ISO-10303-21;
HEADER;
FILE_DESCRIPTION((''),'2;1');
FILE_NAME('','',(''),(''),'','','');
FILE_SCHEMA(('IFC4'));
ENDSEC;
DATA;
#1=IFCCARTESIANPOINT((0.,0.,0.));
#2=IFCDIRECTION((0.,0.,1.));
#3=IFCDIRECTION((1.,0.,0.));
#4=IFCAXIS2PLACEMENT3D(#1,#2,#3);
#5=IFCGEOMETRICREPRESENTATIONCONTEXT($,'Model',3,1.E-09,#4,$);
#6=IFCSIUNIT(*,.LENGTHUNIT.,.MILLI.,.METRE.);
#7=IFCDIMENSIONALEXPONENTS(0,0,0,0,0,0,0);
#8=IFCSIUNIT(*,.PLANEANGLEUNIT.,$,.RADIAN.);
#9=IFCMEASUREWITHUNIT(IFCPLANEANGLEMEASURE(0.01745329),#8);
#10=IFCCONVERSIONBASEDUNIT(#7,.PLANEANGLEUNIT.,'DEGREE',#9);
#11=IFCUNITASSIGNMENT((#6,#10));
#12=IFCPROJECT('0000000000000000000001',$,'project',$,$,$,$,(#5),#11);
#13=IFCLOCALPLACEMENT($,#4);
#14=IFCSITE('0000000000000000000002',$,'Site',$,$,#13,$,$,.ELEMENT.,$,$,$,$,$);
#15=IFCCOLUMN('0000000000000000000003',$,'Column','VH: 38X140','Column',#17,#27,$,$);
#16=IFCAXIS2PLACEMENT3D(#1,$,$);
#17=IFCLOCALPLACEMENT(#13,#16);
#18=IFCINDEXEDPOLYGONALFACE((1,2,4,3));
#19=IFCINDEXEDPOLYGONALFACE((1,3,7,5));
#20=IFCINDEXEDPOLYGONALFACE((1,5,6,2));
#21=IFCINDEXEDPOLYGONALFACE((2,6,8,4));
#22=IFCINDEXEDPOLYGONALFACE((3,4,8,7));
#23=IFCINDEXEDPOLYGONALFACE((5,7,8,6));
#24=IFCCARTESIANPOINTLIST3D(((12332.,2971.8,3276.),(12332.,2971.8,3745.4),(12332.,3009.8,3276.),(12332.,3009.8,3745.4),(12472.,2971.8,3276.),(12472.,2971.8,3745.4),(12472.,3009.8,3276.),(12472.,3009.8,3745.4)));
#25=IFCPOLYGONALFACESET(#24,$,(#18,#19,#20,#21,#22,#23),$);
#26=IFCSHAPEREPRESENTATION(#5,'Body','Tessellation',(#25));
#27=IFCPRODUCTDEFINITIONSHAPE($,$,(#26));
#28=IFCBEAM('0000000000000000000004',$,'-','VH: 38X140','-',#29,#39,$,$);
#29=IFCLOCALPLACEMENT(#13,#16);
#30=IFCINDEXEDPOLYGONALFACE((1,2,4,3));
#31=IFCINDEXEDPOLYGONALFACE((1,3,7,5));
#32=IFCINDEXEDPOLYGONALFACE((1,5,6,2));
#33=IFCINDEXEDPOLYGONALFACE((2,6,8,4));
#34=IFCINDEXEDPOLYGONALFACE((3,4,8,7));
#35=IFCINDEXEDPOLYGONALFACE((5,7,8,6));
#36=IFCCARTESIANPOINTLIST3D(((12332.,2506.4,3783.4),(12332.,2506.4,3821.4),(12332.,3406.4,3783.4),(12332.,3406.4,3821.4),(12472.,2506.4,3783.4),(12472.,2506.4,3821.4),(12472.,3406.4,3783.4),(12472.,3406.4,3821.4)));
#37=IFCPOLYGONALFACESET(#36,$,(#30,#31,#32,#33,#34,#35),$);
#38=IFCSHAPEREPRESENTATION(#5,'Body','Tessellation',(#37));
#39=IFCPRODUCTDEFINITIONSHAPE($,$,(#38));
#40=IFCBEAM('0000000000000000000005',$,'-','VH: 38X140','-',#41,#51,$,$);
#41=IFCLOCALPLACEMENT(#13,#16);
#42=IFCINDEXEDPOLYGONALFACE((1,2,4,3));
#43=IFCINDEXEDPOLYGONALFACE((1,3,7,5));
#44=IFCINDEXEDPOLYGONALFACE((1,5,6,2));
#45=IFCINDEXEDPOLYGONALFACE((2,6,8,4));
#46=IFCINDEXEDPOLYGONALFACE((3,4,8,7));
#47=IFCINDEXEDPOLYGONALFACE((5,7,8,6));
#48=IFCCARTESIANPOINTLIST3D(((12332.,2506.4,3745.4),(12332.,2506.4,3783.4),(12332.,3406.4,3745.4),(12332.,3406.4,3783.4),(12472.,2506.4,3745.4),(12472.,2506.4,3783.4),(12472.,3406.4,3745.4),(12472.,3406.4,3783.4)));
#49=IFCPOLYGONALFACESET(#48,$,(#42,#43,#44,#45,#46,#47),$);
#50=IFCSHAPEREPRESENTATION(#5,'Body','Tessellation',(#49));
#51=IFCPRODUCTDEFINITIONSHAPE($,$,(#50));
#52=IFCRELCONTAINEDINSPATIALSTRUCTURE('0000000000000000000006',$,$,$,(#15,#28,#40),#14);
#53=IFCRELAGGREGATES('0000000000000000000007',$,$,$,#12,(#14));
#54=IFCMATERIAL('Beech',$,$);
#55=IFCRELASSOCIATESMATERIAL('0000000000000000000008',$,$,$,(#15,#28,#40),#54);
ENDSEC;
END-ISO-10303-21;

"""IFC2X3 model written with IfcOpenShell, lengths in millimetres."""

from ifc_helpers import new_model, entity, si_unit, converted_unit, frame, origin, origin_with_axes, origin_2d, place, context, project, spatial, rectangle, extrude, material, element, save


model = new_model("IFC2X3")

# Units and contexts
model_context = context("Model", 3, precision=1e-09, world=origin_with_axes())
ifc_project = project(units=[si_unit("LENGTHUNIT", "METRE", prefix="MILLI"), converted_unit("PLANEANGLEUNIT", "DEGREE", entity("IfcPlaneAngleMeasure", 0.01745329), si_unit("PLANEANGLEUNIT", "RADIAN"), dimensions=[0, 0, 0, 0, 0, 0, 0])], contexts=[model_context])

# Site
site_placement = place(None, origin_with_axes())
site = spatial("IfcSite", under=ifc_project, at=site_placement, Name="Site", CompositionType="ELEMENT")

# Column
ifc_material = material(Name="Beech")
column_1_placement = place(None, frame((12402.0, 2990.8, 3276.0), z_axis=(0.0, 0.0, 1.0), x_axis=(0.0, -1.0, 0.0)))
element("IfcColumn", 1, at=column_1_placement, inside=site, material=ifc_material, Name="Column", Description="VH: 38X140", ObjectType="Column", context=model_context, shape_type="SweptSolid", body=[
    extrude(rectangle(XDim=38.0, YDim=140.0, at=origin_2d()), origin(), (0.0, 0.0, 1.0), 469.4),
])

# Beams
for number, where, z_axis, x_axis, name in (
    (2, (12402.0, 3406.4, 3802.4), (0.0, -1.0, 0.0), (0.0, 0.0, -1.0), "-"),
    (3, (12402.0, 3406.4, 3764.4), (0.0, -1.0, 0.0), (0.0, 0.0, -1.0), "-"),
):
    element("IfcBeam", number, at=place(None, frame(where, z_axis=z_axis, x_axis=x_axis)), inside=site, material=ifc_material, Name=name, Description="VH: 38X140", ObjectType="-", context=model_context, shape_type="SweptSolid", body=[
        extrude(rectangle(XDim=38.0, YDim=140.0, at=origin_2d()), origin(), (0.0, 0.0, 1.0), 900.0),
    ])

save(model, "model.ifc")
